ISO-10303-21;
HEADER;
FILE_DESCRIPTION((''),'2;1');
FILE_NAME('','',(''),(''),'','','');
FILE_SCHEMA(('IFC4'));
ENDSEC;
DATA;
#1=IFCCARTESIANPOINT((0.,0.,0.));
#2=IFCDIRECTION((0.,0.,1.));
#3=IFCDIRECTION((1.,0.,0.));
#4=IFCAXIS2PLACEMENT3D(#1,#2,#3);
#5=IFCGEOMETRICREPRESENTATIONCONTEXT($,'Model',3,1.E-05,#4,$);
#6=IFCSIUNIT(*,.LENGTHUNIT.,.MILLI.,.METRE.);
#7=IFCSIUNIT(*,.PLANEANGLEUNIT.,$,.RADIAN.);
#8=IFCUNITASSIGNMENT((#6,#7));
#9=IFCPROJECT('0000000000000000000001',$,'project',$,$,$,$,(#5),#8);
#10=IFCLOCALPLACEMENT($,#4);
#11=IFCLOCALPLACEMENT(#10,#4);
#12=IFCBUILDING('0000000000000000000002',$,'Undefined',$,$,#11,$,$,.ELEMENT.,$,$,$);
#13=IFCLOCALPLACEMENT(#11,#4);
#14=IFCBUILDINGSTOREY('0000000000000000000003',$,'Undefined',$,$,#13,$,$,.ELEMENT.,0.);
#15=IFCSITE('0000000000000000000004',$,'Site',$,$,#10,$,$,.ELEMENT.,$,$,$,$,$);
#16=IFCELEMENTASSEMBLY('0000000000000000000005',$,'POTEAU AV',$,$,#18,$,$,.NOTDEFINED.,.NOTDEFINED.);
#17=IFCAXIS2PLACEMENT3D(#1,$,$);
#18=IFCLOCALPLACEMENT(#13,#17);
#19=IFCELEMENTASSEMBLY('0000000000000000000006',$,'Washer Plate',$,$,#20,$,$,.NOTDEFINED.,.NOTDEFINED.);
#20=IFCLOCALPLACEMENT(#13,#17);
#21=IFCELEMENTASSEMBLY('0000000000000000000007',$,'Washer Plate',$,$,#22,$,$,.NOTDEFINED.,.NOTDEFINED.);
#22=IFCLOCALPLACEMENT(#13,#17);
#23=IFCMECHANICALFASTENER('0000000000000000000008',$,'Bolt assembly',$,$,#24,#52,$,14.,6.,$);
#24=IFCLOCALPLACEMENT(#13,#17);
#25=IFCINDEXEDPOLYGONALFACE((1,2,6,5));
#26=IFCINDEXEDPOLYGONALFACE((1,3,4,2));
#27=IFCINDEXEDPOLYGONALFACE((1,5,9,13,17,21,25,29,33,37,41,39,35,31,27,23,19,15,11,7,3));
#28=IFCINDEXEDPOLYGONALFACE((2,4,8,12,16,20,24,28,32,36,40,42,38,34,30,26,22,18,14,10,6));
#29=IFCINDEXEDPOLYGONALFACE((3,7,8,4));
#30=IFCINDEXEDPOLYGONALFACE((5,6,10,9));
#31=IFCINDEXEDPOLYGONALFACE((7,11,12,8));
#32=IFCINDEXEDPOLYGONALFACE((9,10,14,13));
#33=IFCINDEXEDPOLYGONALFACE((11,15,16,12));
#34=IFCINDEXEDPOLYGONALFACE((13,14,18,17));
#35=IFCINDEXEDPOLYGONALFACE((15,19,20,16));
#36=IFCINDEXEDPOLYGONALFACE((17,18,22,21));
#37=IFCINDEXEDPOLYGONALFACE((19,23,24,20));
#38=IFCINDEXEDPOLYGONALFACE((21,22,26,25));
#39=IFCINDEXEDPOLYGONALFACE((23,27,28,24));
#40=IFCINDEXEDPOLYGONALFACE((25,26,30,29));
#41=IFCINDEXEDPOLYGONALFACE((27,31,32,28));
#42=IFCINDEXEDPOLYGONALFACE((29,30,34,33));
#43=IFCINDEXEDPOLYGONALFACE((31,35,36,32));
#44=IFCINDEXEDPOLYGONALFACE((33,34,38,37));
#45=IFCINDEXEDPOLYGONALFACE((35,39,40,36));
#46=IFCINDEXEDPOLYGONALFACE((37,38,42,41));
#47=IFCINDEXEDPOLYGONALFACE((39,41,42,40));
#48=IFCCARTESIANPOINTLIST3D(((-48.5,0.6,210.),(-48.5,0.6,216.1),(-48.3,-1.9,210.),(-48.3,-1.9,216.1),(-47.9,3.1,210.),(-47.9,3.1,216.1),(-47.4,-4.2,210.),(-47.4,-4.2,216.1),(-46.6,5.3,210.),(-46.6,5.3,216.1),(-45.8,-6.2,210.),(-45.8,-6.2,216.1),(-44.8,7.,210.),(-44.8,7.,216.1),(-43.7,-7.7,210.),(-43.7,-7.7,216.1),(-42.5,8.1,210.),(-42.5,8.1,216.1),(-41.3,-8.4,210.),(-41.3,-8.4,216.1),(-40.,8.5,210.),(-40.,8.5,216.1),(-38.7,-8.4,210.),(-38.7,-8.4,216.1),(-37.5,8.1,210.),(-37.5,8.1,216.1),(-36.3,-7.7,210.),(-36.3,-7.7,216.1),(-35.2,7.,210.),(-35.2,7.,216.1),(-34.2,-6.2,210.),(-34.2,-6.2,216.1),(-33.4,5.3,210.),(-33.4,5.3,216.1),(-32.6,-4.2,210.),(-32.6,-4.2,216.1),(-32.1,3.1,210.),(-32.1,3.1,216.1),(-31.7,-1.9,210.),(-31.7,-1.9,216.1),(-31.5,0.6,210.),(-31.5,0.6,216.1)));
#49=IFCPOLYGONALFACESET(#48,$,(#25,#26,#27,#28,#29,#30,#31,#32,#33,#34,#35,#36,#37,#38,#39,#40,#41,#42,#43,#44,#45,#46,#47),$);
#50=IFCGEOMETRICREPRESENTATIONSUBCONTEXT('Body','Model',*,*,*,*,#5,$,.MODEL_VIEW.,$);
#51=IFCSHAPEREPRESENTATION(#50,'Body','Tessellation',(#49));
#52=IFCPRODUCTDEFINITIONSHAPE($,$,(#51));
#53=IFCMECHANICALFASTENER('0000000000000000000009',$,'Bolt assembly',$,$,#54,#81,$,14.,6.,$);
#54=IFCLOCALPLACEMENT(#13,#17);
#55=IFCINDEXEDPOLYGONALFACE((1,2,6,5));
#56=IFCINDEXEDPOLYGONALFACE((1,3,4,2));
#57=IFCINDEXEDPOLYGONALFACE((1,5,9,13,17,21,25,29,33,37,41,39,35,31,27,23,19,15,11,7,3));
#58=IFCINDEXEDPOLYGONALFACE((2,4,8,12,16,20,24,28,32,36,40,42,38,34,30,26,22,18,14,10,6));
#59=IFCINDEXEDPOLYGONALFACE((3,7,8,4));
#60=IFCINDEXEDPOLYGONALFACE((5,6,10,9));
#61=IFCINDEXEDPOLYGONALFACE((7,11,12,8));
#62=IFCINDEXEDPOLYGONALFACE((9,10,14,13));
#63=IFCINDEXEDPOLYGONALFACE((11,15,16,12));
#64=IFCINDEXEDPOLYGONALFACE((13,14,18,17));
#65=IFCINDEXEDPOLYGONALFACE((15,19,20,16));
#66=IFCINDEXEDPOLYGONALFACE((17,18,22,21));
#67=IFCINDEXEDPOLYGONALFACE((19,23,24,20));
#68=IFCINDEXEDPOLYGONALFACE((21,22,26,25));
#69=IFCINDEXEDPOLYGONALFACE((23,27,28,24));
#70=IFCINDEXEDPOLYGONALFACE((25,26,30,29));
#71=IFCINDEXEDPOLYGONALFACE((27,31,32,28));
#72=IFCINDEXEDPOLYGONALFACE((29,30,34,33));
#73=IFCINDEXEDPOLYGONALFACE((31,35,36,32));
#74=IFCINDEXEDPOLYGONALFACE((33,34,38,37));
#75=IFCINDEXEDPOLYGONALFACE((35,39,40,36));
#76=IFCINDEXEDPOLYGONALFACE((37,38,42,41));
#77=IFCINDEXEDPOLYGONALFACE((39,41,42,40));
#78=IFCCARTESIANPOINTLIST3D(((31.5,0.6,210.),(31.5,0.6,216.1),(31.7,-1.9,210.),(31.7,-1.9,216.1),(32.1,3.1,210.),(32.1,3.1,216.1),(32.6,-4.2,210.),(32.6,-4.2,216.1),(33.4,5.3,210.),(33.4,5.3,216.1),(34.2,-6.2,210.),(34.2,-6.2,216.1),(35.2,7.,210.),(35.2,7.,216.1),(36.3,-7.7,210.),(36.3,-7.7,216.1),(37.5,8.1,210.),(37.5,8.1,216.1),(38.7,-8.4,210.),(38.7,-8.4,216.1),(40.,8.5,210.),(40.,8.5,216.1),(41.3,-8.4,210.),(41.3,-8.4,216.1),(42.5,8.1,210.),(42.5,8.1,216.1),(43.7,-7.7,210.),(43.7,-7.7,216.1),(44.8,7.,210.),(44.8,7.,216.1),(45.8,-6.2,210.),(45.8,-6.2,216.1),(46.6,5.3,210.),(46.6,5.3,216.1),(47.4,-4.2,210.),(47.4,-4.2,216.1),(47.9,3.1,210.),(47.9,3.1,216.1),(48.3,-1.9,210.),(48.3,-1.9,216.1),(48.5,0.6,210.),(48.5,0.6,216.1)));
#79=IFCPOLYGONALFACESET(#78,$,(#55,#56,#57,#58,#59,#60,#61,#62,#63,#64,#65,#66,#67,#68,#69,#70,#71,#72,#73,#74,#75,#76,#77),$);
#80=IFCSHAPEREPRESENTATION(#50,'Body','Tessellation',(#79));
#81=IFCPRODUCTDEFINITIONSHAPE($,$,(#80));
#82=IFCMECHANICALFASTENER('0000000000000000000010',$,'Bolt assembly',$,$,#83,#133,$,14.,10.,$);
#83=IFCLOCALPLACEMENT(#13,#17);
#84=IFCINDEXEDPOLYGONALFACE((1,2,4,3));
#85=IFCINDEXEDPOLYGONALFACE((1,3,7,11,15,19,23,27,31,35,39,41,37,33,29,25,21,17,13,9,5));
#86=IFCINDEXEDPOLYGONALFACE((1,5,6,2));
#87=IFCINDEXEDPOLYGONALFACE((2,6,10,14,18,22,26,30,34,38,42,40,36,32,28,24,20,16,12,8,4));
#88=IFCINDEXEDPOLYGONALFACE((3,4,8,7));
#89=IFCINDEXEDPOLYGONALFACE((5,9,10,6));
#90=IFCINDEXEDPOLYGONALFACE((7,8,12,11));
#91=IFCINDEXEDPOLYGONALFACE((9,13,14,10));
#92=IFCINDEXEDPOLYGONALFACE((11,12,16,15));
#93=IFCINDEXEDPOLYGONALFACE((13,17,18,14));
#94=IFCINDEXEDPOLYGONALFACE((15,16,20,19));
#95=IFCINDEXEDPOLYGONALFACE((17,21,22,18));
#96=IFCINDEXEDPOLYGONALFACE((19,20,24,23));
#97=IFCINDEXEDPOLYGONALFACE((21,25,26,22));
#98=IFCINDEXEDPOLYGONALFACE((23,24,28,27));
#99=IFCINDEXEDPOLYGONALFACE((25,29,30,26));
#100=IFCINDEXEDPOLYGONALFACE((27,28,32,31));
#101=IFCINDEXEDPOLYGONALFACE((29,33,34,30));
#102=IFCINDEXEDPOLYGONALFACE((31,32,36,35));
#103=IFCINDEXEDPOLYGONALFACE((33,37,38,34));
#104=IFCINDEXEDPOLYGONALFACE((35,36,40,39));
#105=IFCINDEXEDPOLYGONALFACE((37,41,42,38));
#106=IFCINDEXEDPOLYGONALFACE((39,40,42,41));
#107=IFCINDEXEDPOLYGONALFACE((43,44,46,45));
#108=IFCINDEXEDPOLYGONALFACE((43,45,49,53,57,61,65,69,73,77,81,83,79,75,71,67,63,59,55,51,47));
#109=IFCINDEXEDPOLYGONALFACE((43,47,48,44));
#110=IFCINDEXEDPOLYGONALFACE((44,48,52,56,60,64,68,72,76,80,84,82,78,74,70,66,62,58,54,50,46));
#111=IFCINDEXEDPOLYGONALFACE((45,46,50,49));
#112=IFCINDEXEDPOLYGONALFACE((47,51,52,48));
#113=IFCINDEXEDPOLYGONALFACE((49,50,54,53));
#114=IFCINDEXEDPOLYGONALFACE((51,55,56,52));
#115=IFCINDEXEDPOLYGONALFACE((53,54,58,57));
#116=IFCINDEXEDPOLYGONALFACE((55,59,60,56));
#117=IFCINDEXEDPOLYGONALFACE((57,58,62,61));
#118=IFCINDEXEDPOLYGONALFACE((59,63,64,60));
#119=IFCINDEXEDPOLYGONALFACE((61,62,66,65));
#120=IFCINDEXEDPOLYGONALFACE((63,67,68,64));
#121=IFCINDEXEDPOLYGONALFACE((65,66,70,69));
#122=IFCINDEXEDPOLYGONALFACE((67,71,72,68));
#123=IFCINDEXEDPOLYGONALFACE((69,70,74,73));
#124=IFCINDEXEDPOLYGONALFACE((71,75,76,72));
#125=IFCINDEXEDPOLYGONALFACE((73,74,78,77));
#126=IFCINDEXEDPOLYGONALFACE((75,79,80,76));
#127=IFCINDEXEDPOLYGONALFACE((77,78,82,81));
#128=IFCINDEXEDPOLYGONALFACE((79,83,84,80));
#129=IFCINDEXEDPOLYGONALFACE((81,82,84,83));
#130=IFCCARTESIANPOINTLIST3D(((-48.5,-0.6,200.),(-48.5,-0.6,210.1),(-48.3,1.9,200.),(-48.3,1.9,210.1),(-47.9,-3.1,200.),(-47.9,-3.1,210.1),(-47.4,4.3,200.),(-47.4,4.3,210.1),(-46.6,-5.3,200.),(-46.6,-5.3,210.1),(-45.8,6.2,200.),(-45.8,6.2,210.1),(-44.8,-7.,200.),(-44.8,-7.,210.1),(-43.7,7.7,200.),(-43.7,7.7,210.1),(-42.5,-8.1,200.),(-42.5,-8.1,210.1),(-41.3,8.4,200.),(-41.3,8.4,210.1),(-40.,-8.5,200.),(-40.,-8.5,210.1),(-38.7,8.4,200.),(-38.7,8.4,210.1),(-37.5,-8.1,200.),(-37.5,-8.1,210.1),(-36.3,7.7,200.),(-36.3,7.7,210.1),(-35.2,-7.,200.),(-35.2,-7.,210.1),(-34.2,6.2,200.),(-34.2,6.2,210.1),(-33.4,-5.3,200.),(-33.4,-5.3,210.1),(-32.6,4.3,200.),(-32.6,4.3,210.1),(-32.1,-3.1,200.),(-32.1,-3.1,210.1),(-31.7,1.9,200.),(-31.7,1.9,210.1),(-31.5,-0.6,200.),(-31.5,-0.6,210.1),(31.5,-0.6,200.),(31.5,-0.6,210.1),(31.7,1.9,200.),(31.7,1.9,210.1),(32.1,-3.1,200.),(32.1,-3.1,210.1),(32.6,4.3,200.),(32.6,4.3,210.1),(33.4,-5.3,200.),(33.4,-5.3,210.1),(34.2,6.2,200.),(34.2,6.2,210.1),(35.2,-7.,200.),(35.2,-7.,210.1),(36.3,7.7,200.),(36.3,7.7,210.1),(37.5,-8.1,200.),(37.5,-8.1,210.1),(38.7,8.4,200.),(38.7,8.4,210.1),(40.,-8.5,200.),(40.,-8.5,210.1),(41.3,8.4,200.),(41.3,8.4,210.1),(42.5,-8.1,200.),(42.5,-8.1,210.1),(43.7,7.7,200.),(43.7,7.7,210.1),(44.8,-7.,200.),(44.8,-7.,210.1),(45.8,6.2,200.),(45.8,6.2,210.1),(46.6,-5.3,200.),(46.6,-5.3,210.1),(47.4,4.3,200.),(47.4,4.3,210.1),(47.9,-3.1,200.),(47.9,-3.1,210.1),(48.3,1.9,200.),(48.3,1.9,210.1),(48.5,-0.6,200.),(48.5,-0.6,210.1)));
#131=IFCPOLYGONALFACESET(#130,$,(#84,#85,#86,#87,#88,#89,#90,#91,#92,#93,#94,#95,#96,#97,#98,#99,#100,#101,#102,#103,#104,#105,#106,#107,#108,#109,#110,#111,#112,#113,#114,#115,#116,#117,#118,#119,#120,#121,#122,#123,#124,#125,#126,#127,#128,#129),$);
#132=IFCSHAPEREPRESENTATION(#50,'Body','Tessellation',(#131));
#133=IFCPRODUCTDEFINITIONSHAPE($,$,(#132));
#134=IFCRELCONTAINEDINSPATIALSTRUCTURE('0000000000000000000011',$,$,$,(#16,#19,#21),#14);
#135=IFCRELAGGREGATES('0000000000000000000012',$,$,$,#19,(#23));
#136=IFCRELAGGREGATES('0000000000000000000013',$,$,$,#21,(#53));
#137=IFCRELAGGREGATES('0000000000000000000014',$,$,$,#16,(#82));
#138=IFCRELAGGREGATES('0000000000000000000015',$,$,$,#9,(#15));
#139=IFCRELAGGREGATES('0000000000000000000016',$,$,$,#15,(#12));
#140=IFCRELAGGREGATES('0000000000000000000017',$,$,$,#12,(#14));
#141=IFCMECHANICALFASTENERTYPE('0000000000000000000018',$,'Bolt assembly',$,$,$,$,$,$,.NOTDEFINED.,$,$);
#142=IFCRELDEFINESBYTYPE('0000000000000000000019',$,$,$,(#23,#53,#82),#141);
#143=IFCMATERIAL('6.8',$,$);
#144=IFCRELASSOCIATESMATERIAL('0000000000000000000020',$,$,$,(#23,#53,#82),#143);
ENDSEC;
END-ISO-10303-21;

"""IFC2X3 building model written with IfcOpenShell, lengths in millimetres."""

from ifc_helpers import new_model, si_unit, frame, origin_with_axes, origin_2d_with_axis, place, context, subcontext, project, spatial, circle, extrude, source, transform, mapped, material, type_object, element, aggregate, save


model = new_model("IFC2X3")

# Units and contexts
model_context = context("Model", 3, precision=1e-05, world=origin_with_axes())
body_context = subcontext(model_context, "Body", "Model", "MODEL_VIEW")
ifc_project = project(units=[si_unit("LENGTHUNIT", "METRE", prefix="MILLI"), si_unit("PLANEANGLEUNIT", "RADIAN")], contexts=[model_context])

# Site, building, storey
site_placement = place(None, origin_with_axes())
site = spatial("IfcSite", under=ifc_project, at=site_placement, Name="Site", CompositionType="ELEMENT")
building_placement = place(site_placement, origin_with_axes())
building = spatial("IfcBuilding", under=site, at=building_placement, Name="Undefined", CompositionType="ELEMENT")
storey_placement = place(building_placement, origin_with_axes())
storey = spatial("IfcBuildingStorey", under=building, at=storey_placement, Name="Undefined", CompositionType="ELEMENT", Elevation=0.0)

# Element assembly
assembly_1_placement = place(storey_placement, origin_with_axes())
assembly_1 = element("IfcElementAssembly", 1, at=assembly_1_placement, inside=storey, Name="POTEAU AV", AssemblyPlace="NOTDEFINED", PredefinedType="NOTDEFINED")

# Element assemblies
assembly_2_placement = place(storey_placement, origin_with_axes())
assembly_2 = element("IfcElementAssembly", 2, at=assembly_2_placement, inside=storey, Name="Washer Plate", AssemblyPlace="NOTDEFINED", PredefinedType="NOTDEFINED")
assembly_3_placement = place(storey_placement, origin_with_axes())
assembly_3 = element("IfcElementAssembly", 3, at=assembly_3_placement, inside=storey, Name="Washer Plate", AssemblyPlace="NOTDEFINED", PredefinedType="NOTDEFINED")

# Shared definitions
mechanical_fastener_type = type_object("IfcMechanicalFastenerType", Name="Bolt assembly")

# Mechanical fasteners
ifc_material_1 = material(Name="6.8")
shared_shape_1 = source(origin_with_axes(), body_context, "Body", "SweptSolid", [
    extrude(circle(Radius=8.5, at=origin_2d_with_axis()), frame((0.0, 0.0, 0.0), z_axis=(0.0, 1.0, 0.0), x_axis=(1.0, 0.0, 0.0)), (0.0, 0.0, 1.0), 6.1),
])
mechanical_fastener_1_placement = place(assembly_2_placement, frame((-40.0, 0.0, 210.0), z_axis=(1.0, 0.0, 0.0), x_axis=(0.0, 1.0, 0.0)))
mechanical_fastener_1 = element("IfcMechanicalFastener", 4, at=mechanical_fastener_1_placement, type_object=mechanical_fastener_type, material=ifc_material_1, Name="Bolt assembly", NominalDiameter=14.0, NominalLength=6.0, context=body_context, shape_type="MappedRepresentation", body=[
    mapped(shared_shape_1, transform((0.0, 0.0, 0.0))),
])
aggregate(assembly_2, [mechanical_fastener_1])
mechanical_fastener_2_placement = place(assembly_3_placement, frame((40.0, 0.0, 210.0), z_axis=(1.0, 0.0, 0.0), x_axis=(0.0, 1.0, 0.0)))
mechanical_fastener_2 = element("IfcMechanicalFastener", 5, at=mechanical_fastener_2_placement, type_object=mechanical_fastener_type, material=ifc_material_1, Name="Bolt assembly", NominalDiameter=14.0, NominalLength=6.0, context=body_context, shape_type="MappedRepresentation", body=[
    mapped(shared_shape_1, transform((0.0, 0.0, 0.0))),
])
aggregate(assembly_3, [mechanical_fastener_2])
shared_shape_2 = source(origin_with_axes(), body_context, "Body", "SweptSolid", [
    extrude(circle(Radius=8.5, at=origin_2d_with_axis()), frame((0.0, -10.0, 0.0), z_axis=(0.0, 1.0, 0.0), x_axis=(1.0, 0.0, 0.0)), (0.0, 0.0, 1.0), 10.1),
])
mechanical_fastener_3_placement = place(assembly_1_placement, frame((0.0, 48.0, 210.0), z_axis=(-1.0, 0.0, 0.0), x_axis=(0.0, -1.0, 0.0)))
mechanical_fastener_3 = element("IfcMechanicalFastener", 6, at=mechanical_fastener_3_placement, type_object=mechanical_fastener_type, material=ifc_material_1, Name="Bolt assembly", NominalDiameter=14.0, NominalLength=10.0, context=body_context, shape_type="MappedRepresentation", body=[
    mapped(shared_shape_2, transform((48.0, 0.0, -40.0))),
    mapped(shared_shape_2, transform((48.0, 0.0, 40.0))),
])
aggregate(assembly_1, [mechanical_fastener_3])

save(model, "model.ifc")
